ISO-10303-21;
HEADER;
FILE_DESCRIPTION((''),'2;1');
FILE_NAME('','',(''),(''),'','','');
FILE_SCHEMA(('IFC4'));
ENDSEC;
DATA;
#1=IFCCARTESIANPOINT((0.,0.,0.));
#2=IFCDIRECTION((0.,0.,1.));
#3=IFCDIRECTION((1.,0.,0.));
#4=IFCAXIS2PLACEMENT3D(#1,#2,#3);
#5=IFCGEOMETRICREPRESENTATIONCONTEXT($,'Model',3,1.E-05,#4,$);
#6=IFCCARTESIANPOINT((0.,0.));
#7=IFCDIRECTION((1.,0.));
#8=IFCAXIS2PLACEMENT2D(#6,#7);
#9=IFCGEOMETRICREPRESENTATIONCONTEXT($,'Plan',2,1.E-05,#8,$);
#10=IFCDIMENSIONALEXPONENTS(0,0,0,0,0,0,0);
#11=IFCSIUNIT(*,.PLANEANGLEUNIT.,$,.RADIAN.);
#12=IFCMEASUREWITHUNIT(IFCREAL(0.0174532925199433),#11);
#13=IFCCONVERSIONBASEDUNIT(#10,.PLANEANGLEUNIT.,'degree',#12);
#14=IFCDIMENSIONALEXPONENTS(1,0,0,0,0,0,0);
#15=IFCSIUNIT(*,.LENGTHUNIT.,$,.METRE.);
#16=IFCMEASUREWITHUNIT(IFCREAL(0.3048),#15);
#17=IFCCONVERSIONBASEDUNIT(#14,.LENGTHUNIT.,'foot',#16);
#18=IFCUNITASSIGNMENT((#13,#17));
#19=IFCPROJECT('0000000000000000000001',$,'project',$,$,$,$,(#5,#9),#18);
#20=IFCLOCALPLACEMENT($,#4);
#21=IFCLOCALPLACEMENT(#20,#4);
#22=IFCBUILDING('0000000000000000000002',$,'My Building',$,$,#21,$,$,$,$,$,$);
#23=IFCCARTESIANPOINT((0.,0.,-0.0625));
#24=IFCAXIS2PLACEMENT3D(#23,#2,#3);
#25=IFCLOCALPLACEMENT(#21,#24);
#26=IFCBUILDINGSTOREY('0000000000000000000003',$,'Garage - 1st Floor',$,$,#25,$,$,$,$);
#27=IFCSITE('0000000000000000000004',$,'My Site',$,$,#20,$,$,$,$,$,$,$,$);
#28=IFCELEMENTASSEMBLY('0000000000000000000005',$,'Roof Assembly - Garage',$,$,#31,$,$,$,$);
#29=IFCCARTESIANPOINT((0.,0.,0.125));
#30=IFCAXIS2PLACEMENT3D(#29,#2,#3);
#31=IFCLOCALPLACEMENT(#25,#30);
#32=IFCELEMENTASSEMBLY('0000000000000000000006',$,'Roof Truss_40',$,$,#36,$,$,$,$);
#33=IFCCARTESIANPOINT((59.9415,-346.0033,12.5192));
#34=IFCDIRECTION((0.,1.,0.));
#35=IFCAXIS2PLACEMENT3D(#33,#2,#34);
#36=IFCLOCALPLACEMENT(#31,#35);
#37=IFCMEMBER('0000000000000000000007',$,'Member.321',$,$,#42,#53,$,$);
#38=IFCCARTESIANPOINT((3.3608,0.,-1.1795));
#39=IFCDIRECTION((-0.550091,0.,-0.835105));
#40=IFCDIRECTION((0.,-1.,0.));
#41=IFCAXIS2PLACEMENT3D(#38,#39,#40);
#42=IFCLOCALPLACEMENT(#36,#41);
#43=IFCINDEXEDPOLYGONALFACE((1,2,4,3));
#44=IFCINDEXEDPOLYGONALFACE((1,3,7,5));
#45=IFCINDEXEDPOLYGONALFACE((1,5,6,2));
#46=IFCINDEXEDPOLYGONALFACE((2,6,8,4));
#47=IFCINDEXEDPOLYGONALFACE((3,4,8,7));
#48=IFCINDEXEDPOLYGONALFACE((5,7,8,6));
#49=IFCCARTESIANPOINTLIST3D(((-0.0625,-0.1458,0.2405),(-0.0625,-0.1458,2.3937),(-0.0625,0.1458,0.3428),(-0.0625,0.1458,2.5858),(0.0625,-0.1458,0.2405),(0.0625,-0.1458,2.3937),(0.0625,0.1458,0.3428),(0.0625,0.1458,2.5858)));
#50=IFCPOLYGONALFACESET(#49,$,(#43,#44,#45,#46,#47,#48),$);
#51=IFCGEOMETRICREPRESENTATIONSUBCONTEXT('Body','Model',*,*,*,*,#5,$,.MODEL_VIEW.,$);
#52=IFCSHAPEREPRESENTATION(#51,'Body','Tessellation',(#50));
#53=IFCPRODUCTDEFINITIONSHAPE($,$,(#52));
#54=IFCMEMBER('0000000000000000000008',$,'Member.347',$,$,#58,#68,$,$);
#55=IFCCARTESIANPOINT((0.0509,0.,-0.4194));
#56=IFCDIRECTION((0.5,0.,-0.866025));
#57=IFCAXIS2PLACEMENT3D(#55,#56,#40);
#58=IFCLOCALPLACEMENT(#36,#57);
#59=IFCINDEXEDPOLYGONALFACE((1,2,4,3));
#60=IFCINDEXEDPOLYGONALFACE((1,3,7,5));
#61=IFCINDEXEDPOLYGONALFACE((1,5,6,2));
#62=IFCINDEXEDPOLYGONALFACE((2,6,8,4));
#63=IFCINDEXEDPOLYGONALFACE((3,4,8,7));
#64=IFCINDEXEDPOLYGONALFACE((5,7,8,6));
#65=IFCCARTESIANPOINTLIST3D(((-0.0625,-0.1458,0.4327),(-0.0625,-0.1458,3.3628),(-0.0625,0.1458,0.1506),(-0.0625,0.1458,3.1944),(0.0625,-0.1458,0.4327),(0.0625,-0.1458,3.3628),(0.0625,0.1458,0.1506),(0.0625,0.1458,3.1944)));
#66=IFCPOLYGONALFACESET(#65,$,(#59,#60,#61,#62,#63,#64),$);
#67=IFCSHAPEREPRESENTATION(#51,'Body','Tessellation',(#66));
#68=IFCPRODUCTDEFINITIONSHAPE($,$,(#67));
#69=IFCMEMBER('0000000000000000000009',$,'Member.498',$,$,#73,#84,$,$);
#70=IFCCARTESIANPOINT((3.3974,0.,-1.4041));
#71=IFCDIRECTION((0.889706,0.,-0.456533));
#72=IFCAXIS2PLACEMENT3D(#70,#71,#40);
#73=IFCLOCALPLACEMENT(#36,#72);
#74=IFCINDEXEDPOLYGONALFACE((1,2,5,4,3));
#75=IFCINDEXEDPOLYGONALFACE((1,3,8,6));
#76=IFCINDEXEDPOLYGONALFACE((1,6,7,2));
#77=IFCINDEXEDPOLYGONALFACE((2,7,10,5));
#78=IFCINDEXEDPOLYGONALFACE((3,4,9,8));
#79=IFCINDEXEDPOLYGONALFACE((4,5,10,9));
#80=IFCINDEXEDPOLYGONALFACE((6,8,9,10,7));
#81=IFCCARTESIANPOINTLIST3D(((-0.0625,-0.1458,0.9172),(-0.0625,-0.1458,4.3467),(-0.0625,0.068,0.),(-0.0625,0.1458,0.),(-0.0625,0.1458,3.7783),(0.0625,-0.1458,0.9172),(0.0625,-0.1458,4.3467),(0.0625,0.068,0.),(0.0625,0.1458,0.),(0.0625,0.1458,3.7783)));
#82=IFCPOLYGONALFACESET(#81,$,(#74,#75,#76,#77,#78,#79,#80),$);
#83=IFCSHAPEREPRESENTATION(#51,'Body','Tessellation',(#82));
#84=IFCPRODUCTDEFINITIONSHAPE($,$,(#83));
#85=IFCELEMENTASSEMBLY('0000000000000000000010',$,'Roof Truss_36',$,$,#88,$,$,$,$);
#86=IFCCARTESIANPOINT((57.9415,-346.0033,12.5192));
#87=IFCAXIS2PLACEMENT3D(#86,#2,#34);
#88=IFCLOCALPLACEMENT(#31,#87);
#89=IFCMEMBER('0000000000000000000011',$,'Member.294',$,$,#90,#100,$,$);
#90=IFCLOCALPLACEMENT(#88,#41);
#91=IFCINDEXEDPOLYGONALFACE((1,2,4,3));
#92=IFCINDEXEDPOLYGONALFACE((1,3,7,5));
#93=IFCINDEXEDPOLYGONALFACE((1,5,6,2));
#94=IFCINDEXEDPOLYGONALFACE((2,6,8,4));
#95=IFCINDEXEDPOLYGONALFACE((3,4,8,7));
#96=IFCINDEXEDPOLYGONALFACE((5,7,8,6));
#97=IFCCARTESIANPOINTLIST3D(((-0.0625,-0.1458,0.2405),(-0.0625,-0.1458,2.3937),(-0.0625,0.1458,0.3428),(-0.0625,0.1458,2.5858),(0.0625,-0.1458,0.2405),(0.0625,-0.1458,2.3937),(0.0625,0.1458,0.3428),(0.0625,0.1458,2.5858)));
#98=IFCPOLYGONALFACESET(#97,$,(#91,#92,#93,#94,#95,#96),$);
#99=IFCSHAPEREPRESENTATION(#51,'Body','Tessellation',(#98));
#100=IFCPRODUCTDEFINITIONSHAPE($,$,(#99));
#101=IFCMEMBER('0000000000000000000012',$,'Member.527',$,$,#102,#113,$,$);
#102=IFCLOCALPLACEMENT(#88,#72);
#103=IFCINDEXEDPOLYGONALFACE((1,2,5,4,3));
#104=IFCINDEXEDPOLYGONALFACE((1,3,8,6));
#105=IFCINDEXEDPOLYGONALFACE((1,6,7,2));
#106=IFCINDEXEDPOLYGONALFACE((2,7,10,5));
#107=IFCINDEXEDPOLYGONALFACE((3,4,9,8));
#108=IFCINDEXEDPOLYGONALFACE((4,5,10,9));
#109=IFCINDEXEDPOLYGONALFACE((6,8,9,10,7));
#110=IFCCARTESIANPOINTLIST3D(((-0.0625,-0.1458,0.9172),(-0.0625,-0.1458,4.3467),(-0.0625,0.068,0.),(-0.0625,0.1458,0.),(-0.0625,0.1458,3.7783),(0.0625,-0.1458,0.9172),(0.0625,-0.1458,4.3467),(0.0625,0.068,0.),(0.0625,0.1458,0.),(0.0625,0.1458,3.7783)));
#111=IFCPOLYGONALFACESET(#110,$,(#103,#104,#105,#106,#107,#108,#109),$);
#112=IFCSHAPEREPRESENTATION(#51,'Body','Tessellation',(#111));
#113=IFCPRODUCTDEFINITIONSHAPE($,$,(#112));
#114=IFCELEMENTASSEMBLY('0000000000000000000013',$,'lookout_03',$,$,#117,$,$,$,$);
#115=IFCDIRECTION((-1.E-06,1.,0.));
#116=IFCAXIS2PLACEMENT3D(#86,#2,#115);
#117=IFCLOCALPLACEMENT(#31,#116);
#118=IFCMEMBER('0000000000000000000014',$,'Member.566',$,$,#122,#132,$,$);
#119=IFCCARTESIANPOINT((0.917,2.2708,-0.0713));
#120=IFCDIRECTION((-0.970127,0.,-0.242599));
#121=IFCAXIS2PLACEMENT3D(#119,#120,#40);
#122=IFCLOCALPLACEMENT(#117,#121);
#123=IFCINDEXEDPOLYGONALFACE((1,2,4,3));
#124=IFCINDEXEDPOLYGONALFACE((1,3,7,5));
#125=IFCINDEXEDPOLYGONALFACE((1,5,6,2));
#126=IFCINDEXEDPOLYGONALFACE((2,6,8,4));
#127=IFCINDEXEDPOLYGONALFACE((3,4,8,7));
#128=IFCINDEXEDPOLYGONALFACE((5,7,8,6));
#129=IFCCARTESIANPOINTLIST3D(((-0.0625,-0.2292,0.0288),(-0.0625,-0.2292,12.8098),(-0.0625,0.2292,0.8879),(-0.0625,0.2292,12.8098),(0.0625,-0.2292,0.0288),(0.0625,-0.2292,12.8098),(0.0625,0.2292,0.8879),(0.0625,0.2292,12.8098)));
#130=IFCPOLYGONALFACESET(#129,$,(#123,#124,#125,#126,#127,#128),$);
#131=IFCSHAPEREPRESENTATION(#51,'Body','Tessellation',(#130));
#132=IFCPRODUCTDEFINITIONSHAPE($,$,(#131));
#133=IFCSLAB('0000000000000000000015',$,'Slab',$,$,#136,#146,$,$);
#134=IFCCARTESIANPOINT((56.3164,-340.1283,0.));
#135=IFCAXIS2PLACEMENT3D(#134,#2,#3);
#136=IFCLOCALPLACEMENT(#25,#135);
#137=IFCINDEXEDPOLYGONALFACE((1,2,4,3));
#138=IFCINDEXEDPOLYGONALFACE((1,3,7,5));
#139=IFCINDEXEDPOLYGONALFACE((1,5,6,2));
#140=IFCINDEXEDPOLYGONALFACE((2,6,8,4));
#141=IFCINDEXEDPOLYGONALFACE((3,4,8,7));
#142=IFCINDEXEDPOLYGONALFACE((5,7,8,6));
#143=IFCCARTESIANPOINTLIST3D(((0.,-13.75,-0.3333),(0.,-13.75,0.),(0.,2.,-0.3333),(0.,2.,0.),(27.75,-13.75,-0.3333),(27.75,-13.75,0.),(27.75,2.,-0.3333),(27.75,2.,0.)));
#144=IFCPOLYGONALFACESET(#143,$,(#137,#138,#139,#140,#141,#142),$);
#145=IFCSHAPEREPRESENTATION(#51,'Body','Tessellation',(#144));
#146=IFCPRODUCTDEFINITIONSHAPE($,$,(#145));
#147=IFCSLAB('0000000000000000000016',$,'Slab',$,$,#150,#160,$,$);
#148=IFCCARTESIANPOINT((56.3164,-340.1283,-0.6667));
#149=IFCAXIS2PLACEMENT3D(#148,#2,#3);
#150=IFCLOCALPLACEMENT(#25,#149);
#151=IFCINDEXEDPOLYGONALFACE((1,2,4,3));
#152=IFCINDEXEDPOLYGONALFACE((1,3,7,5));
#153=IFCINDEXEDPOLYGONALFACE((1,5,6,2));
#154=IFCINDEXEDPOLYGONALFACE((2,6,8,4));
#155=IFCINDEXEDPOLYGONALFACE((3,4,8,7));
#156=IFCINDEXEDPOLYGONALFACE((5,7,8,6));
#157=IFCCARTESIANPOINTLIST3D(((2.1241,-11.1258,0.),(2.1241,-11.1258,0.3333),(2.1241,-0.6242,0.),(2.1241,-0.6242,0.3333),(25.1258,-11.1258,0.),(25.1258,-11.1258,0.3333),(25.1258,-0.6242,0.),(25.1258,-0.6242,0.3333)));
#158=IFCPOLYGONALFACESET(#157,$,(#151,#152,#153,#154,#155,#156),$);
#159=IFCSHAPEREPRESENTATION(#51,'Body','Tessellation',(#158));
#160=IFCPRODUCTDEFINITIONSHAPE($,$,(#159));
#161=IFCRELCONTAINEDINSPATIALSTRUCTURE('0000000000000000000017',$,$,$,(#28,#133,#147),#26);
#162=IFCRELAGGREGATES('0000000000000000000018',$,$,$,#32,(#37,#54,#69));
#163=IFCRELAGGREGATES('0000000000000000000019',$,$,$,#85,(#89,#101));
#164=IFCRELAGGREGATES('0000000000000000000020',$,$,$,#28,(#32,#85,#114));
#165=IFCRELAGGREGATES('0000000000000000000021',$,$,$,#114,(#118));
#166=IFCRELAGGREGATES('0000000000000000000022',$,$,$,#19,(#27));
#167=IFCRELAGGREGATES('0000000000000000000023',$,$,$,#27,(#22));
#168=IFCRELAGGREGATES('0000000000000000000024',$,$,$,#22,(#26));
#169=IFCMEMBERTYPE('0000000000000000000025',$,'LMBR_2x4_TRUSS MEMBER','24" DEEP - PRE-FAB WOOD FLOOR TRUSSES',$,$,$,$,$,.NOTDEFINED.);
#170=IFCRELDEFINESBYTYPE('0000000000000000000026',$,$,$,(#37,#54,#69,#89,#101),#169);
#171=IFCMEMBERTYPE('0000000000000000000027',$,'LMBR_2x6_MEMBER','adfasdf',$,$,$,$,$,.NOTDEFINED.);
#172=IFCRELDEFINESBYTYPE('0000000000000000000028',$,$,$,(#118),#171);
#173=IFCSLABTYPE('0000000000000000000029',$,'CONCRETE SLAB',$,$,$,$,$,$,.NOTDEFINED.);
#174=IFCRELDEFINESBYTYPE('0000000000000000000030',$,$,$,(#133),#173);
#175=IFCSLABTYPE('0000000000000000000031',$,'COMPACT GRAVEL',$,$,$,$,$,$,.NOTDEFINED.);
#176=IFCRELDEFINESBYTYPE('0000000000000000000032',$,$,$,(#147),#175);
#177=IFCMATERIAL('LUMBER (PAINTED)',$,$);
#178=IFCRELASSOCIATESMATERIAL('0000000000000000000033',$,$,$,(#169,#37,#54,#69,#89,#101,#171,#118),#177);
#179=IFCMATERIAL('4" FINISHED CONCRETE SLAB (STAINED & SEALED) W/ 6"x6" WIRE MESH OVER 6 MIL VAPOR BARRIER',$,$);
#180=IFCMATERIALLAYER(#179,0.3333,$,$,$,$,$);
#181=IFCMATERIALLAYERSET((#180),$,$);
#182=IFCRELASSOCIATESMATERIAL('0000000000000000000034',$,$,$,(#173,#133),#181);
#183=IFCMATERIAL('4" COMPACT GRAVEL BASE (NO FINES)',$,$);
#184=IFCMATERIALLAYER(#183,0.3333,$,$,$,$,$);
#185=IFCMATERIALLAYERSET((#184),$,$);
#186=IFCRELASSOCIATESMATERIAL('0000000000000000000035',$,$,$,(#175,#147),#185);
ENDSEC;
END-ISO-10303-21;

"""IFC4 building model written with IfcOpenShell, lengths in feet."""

from ifc_helpers import new_model, entity, si_unit, converted_unit, frame, origin_with_axes, origin_2d_with_axis, place, context, subcontext, project, spatial, indexed_curve, outline, extrude, clip, halfspace, material, layer, layer_set, layer_usage, material_profile, profile_set, profile_usage, type_object, element, aggregate, save


model = new_model("IFC4")

# Units and contexts
model_context = context("Model", 3, precision=1e-05, world=origin_with_axes())
plan_context = context("Plan", 2, precision=1e-05, world=origin_2d_with_axis())
body_context = subcontext(model_context, "Body", "Model", "MODEL_VIEW")
ifc_project = project(units=[converted_unit("PLANEANGLEUNIT", "degree", entity("IfcReal", 0.0174532925199433), si_unit("PLANEANGLEUNIT", "RADIAN"), dimensions=[0, 0, 0, 0, 0, 0, 0]), converted_unit("LENGTHUNIT", "foot", entity("IfcReal", 0.3048), si_unit("LENGTHUNIT", "METRE"), dimensions=[1, 0, 0, 0, 0, 0, 0])], contexts=[model_context, plan_context])

# Site, building, storey
site_placement = place(None, origin_with_axes())
site = spatial("IfcSite", under=ifc_project, at=site_placement, Name="My Site")
building_placement = place(site_placement, origin_with_axes())
building = spatial("IfcBuilding", under=site, at=building_placement, Name="My Building")
storey_placement = place(building_placement, frame((0.0, 0.0, -0.0625), z_axis=(0.0, 0.0, 1.0), x_axis=(1.0, 0.0, 0.0)))
storey = spatial("IfcBuildingStorey", under=building, at=storey_placement, Name="Garage - 1st Floor")

# Element assemblies, members
assembly_1_placement = place(storey_placement, frame((0.0, 0.0, 0.125), z_axis=(0.0, 0.0, 1.0), x_axis=(1.0, 0.0, 0.0)))
assembly_1 = element("IfcElementAssembly", 1, at=assembly_1_placement, inside=storey, Name="Roof Assembly - Garage")
assembly_2_placement = place(assembly_1_placement, frame((59.9415, -346.0033, 12.5192), z_axis=(0.0, 0.0, 1.0), x_axis=(0.0, 1.0, 0.0)))
assembly_2 = element("IfcElementAssembly", 2, at=assembly_2_placement, Name="Roof Truss_40")
ifc_material_1 = material(Name="LUMBER (PAINTED)")
ifc_material_profile_1 = material_profile(ifc_material_1, outline(indexed_curve([(-0.0625, -0.1458), (0.0625, -0.1458), (0.0625, 0.1458), (-0.0625, 0.1458), (-0.0625, -0.1458)])))
ifc_profile_set_1 = profile_set([ifc_material_profile_1])
ifc_profile_usage_1 = profile_usage(ifc_profile_set_1)
member_type_1 = type_object("IfcMemberType", Name="LMBR_2x4_TRUSS MEMBER", Description="24\" DEEP - PRE-FAB WOOD FLOOR TRUSSES", PredefinedType="NOTDEFINED", material=ifc_profile_set_1)
member_1_placement = place(assembly_2_placement, frame((3.3608, 0.0, -1.1795), z_axis=(-0.550091, 0.0, -0.835105), x_axis=(0.0, -1.0, 0.0)))
member_1 = element("IfcMember", 3, at=member_1_placement, type_object=member_type_1, material=ifc_profile_usage_1, Name="Member.321", context=body_context, shape_type="Clipping", body=[
    clip(clip(extrude(outline(indexed_curve([(-0.0625, -0.1458), (0.0625, -0.1458), (0.0625, 0.1458), (-0.0625, 0.1458), (-0.0625, -0.1458)])), origin_with_axes(), (0.0, 0.0, 1.0), 2.7814), halfspace(frame((0.0, 3.2555, 1.4338), z_axis=(0.0, 0.331062, -0.943609), x_axis=(1.0, 0.0, 0.0)), False)), halfspace(frame((0.0, -4.6352, -0.5634), z_axis=(0.0, -0.550091, 0.835105), x_axis=(-1.0, 0.0, 0.0)), False)),
])
ifc_profile_usage_2 = profile_usage(ifc_profile_set_1)
member_2_placement = place(assembly_2_placement, frame((0.0509, 0.0, -0.4194), z_axis=(0.5, 0.0, -0.866025), x_axis=(0.0, -1.0, 0.0)))
member_2 = element("IfcMember", 4, at=member_2_placement, type_object=member_type_1, material=ifc_profile_usage_2, Name="Member.347", context=body_context, shape_type="Clipping", body=[
    clip(clip(extrude(outline(indexed_curve([(-0.0625, -0.1458), (0.0625, -0.1458), (0.0625, 0.1458), (-0.0625, 0.1458), (-0.0625, -0.1458)])), origin_with_axes(), (0.0, 0.0, 1.0), 3.5703), halfspace(frame((0.0, -5.0674, 6.2043), z_axis=(0.0, 0.5, 0.866025), x_axis=(1.0, 0.0, 0.0)), False)), halfspace(frame((0.0, 0.2544, 0.0456), z_axis=(0.0, -0.695161, -0.718855), x_axis=(-1.0, 0.0, 0.0)), False)),
])
ifc_profile_usage_3 = profile_usage(ifc_profile_set_1)
member_3_placement = place(assembly_2_placement, frame((3.3974, 0.0, -1.4041), z_axis=(0.889706, 0.0, -0.456533), x_axis=(0.0, -1.0, 0.0)))
member_3 = element("IfcMember", 5, at=member_3_placement, type_object=member_type_1, material=ifc_profile_usage_3, Name="Member.498", context=body_context, shape_type="Clipping", body=[
    clip(clip(extrude(outline(indexed_curve([(-0.0625, -0.1458), (0.0625, -0.1458), (0.0625, 0.1458), (-0.0625, 0.1458), (-0.0625, -0.1458)])), origin_with_axes(), (0.0, 0.0, 1.0), 4.3542), halfspace(frame((0.0, -0.2419, 4.5339), z_axis=(0.0, 0.889707, 0.456533), x_axis=(1.0, 0.0, 0.0)), False)), halfspace(frame((0.0, 0.8902, -3.5265), z_axis=(0.0, -0.973882, -0.227053), x_axis=(-1.0, 0.0, 0.0)), False)),
])
assembly_3_placement = place(assembly_1_placement, frame((57.9415, -346.0033, 12.5192), z_axis=(0.0, 0.0, 1.0), x_axis=(0.0, 1.0, 0.0)))
assembly_3 = element("IfcElementAssembly", 6, at=assembly_3_placement, Name="Roof Truss_36")
ifc_profile_usage_4 = profile_usage(ifc_profile_set_1)
member_4_placement = place(assembly_3_placement, frame((3.3608, 0.0, -1.1795), z_axis=(-0.550091, 0.0, -0.835105), x_axis=(0.0, -1.0, 0.0)))
member_4 = element("IfcMember", 7, at=member_4_placement, type_object=member_type_1, material=ifc_profile_usage_4, Name="Member.294", context=body_context, shape_type="Clipping", body=[
    clip(clip(extrude(outline(indexed_curve([(-0.0625, -0.1458), (0.0625, -0.1458), (0.0625, 0.1458), (-0.0625, 0.1458), (-0.0625, -0.1458)])), origin_with_axes(), (0.0, 0.0, 1.0), 2.7814), halfspace(frame((0.0, 3.2555, 1.4338), z_axis=(0.0, 0.331062, -0.943609), x_axis=(1.0, 0.0, 0.0)), False)), halfspace(frame((0.0, -4.6352, -0.5634), z_axis=(0.0, -0.550091, 0.835105), x_axis=(-1.0, 0.0, 0.0)), False)),
])
ifc_profile_usage_5 = profile_usage(ifc_profile_set_1)
member_5_placement = place(assembly_3_placement, frame((3.3974, 0.0, -1.4041), z_axis=(0.889706, 0.0, -0.456533), x_axis=(0.0, -1.0, 0.0)))
member_5 = element("IfcMember", 8, at=member_5_placement, type_object=member_type_1, material=ifc_profile_usage_5, Name="Member.527", context=body_context, shape_type="Clipping", body=[
    clip(clip(extrude(outline(indexed_curve([(-0.0625, -0.1458), (0.0625, -0.1458), (0.0625, 0.1458), (-0.0625, 0.1458), (-0.0625, -0.1458)])), origin_with_axes(), (0.0, 0.0, 1.0), 4.3542), halfspace(frame((0.0, -0.2419, 4.5339), z_axis=(0.0, 0.889707, 0.456533), x_axis=(1.0, 0.0, 0.0)), False)), halfspace(frame((0.0, 0.8902, -3.5265), z_axis=(0.0, -0.973882, -0.227053), x_axis=(-1.0, 0.0, 0.0)), False)),
])
assembly_4_placement = place(assembly_1_placement, frame((57.9415, -346.0033, 12.5192), z_axis=(0.0, 0.0, 1.0), x_axis=(-0.000001, 1.0, 0.0)))
assembly_4 = element("IfcElementAssembly", 9, at=assembly_4_placement, Name="lookout_03")
ifc_material_profile_2 = material_profile(ifc_material_1, outline(indexed_curve([(-0.0625, 0.2292), (0.0625, 0.2292), (0.0625, -0.2292), (-0.0625, -0.2292), (-0.0625, 0.2292)])))
ifc_profile_set_2 = profile_set([ifc_material_profile_2])
ifc_profile_usage_6 = profile_usage(ifc_profile_set_2)
member_type_2 = type_object("IfcMemberType", Name="LMBR_2x6_MEMBER", Description="adfasdf", PredefinedType="NOTDEFINED", material=ifc_profile_set_2)
member_6_placement = place(assembly_4_placement, frame((0.917, 2.2708, -0.0713), z_axis=(-0.970127, 0.0, -0.242599), x_axis=(0.0, -1.0, 0.0)))
member_6 = element("IfcMember", 10, at=member_6_placement, type_object=member_type_2, material=ifc_profile_usage_6, Name="Member.566", context=body_context, shape_type="Clipping", body=[
    clip(extrude(outline(indexed_curve([(-0.0625, 0.2292), (0.0625, 0.2292), (0.0625, -0.2292), (-0.0625, -0.2292), (-0.0625, 0.2292)])), origin_with_axes(), (0.0, 0.0, 1.0), 12.8098), halfspace(frame((0.0, 0.1888, 0.8122), z_axis=(0.0, 0.882291, -0.470704), x_axis=(1.0, 0.0, 0.0)), False)),
])
aggregate(assembly_2, [member_1, member_2, member_3])
aggregate(assembly_3, [member_4, member_5])
aggregate(assembly_1, [assembly_2, assembly_3, assembly_4])
aggregate(assembly_4, [member_6])

# Slabs
ifc_material_2 = material(Name="4\" FINISHED CONCRETE SLAB (STAINED & SEALED) W/ 6\"x6\" WIRE MESH OVER 6 MIL VAPOR BARRIER")
ifc_layer_1 = layer(ifc_material_2, 0.3333)
ifc_layer_set_1 = layer_set([ifc_layer_1])
ifc_layer_usage_1 = layer_usage(ifc_layer_set_1, "AXIS3", "POSITIVE", -0.3333)
slab_type_1 = type_object("IfcSlabType", Name="CONCRETE SLAB", PredefinedType="NOTDEFINED", material=ifc_layer_set_1)
slab_1_placement = place(storey_placement, frame((56.3164, -340.1283, 0.0), z_axis=(0.0, 0.0, 1.0), x_axis=(1.0, 0.0, 0.0)))
element("IfcSlab", 11, at=slab_1_placement, inside=storey, type_object=slab_type_1, material=ifc_layer_usage_1, Name="Slab", context=body_context, shape_type="SweptSolid", body=[
    extrude(outline(indexed_curve([(27.75, 2.0), (27.75, -13.75), (0.0, -13.75), (0.0, 2.0), (27.75, 2.0)])), frame((0.0, 0.0, -0.3333), z_axis=(0.0, 0.0, 1.0), x_axis=(1.0, 0.0, 0.0)), (0.0, 0.0, 1.0), 0.3333),
])
ifc_material_3 = material(Name="4\" COMPACT GRAVEL BASE (NO FINES)")
ifc_layer_2 = layer(ifc_material_3, 0.3333)
ifc_layer_set_2 = layer_set([ifc_layer_2])
ifc_layer_usage_2 = layer_usage(ifc_layer_set_2, "AXIS3", "POSITIVE", 0.0)
slab_type_2 = type_object("IfcSlabType", Name="COMPACT GRAVEL", PredefinedType="NOTDEFINED", material=ifc_layer_set_2)
slab_2_placement = place(storey_placement, frame((56.3164, -340.1283, -0.6667), z_axis=(0.0, 0.0, 1.0), x_axis=(1.0, 0.0, 0.0)))
element("IfcSlab", 12, at=slab_2_placement, inside=storey, type_object=slab_type_2, material=ifc_layer_usage_2, Name="Slab", context=body_context, shape_type="SweptSolid", body=[
    extrude(outline(indexed_curve([(2.1241, -0.6242), (2.1241, -11.1258), (25.1258, -11.1258), (25.1258, -0.6242), (2.1241, -0.6242)])), None, (0.0, 0.0, 1.0), 0.3333),
])

save(model, "model.ifc")
